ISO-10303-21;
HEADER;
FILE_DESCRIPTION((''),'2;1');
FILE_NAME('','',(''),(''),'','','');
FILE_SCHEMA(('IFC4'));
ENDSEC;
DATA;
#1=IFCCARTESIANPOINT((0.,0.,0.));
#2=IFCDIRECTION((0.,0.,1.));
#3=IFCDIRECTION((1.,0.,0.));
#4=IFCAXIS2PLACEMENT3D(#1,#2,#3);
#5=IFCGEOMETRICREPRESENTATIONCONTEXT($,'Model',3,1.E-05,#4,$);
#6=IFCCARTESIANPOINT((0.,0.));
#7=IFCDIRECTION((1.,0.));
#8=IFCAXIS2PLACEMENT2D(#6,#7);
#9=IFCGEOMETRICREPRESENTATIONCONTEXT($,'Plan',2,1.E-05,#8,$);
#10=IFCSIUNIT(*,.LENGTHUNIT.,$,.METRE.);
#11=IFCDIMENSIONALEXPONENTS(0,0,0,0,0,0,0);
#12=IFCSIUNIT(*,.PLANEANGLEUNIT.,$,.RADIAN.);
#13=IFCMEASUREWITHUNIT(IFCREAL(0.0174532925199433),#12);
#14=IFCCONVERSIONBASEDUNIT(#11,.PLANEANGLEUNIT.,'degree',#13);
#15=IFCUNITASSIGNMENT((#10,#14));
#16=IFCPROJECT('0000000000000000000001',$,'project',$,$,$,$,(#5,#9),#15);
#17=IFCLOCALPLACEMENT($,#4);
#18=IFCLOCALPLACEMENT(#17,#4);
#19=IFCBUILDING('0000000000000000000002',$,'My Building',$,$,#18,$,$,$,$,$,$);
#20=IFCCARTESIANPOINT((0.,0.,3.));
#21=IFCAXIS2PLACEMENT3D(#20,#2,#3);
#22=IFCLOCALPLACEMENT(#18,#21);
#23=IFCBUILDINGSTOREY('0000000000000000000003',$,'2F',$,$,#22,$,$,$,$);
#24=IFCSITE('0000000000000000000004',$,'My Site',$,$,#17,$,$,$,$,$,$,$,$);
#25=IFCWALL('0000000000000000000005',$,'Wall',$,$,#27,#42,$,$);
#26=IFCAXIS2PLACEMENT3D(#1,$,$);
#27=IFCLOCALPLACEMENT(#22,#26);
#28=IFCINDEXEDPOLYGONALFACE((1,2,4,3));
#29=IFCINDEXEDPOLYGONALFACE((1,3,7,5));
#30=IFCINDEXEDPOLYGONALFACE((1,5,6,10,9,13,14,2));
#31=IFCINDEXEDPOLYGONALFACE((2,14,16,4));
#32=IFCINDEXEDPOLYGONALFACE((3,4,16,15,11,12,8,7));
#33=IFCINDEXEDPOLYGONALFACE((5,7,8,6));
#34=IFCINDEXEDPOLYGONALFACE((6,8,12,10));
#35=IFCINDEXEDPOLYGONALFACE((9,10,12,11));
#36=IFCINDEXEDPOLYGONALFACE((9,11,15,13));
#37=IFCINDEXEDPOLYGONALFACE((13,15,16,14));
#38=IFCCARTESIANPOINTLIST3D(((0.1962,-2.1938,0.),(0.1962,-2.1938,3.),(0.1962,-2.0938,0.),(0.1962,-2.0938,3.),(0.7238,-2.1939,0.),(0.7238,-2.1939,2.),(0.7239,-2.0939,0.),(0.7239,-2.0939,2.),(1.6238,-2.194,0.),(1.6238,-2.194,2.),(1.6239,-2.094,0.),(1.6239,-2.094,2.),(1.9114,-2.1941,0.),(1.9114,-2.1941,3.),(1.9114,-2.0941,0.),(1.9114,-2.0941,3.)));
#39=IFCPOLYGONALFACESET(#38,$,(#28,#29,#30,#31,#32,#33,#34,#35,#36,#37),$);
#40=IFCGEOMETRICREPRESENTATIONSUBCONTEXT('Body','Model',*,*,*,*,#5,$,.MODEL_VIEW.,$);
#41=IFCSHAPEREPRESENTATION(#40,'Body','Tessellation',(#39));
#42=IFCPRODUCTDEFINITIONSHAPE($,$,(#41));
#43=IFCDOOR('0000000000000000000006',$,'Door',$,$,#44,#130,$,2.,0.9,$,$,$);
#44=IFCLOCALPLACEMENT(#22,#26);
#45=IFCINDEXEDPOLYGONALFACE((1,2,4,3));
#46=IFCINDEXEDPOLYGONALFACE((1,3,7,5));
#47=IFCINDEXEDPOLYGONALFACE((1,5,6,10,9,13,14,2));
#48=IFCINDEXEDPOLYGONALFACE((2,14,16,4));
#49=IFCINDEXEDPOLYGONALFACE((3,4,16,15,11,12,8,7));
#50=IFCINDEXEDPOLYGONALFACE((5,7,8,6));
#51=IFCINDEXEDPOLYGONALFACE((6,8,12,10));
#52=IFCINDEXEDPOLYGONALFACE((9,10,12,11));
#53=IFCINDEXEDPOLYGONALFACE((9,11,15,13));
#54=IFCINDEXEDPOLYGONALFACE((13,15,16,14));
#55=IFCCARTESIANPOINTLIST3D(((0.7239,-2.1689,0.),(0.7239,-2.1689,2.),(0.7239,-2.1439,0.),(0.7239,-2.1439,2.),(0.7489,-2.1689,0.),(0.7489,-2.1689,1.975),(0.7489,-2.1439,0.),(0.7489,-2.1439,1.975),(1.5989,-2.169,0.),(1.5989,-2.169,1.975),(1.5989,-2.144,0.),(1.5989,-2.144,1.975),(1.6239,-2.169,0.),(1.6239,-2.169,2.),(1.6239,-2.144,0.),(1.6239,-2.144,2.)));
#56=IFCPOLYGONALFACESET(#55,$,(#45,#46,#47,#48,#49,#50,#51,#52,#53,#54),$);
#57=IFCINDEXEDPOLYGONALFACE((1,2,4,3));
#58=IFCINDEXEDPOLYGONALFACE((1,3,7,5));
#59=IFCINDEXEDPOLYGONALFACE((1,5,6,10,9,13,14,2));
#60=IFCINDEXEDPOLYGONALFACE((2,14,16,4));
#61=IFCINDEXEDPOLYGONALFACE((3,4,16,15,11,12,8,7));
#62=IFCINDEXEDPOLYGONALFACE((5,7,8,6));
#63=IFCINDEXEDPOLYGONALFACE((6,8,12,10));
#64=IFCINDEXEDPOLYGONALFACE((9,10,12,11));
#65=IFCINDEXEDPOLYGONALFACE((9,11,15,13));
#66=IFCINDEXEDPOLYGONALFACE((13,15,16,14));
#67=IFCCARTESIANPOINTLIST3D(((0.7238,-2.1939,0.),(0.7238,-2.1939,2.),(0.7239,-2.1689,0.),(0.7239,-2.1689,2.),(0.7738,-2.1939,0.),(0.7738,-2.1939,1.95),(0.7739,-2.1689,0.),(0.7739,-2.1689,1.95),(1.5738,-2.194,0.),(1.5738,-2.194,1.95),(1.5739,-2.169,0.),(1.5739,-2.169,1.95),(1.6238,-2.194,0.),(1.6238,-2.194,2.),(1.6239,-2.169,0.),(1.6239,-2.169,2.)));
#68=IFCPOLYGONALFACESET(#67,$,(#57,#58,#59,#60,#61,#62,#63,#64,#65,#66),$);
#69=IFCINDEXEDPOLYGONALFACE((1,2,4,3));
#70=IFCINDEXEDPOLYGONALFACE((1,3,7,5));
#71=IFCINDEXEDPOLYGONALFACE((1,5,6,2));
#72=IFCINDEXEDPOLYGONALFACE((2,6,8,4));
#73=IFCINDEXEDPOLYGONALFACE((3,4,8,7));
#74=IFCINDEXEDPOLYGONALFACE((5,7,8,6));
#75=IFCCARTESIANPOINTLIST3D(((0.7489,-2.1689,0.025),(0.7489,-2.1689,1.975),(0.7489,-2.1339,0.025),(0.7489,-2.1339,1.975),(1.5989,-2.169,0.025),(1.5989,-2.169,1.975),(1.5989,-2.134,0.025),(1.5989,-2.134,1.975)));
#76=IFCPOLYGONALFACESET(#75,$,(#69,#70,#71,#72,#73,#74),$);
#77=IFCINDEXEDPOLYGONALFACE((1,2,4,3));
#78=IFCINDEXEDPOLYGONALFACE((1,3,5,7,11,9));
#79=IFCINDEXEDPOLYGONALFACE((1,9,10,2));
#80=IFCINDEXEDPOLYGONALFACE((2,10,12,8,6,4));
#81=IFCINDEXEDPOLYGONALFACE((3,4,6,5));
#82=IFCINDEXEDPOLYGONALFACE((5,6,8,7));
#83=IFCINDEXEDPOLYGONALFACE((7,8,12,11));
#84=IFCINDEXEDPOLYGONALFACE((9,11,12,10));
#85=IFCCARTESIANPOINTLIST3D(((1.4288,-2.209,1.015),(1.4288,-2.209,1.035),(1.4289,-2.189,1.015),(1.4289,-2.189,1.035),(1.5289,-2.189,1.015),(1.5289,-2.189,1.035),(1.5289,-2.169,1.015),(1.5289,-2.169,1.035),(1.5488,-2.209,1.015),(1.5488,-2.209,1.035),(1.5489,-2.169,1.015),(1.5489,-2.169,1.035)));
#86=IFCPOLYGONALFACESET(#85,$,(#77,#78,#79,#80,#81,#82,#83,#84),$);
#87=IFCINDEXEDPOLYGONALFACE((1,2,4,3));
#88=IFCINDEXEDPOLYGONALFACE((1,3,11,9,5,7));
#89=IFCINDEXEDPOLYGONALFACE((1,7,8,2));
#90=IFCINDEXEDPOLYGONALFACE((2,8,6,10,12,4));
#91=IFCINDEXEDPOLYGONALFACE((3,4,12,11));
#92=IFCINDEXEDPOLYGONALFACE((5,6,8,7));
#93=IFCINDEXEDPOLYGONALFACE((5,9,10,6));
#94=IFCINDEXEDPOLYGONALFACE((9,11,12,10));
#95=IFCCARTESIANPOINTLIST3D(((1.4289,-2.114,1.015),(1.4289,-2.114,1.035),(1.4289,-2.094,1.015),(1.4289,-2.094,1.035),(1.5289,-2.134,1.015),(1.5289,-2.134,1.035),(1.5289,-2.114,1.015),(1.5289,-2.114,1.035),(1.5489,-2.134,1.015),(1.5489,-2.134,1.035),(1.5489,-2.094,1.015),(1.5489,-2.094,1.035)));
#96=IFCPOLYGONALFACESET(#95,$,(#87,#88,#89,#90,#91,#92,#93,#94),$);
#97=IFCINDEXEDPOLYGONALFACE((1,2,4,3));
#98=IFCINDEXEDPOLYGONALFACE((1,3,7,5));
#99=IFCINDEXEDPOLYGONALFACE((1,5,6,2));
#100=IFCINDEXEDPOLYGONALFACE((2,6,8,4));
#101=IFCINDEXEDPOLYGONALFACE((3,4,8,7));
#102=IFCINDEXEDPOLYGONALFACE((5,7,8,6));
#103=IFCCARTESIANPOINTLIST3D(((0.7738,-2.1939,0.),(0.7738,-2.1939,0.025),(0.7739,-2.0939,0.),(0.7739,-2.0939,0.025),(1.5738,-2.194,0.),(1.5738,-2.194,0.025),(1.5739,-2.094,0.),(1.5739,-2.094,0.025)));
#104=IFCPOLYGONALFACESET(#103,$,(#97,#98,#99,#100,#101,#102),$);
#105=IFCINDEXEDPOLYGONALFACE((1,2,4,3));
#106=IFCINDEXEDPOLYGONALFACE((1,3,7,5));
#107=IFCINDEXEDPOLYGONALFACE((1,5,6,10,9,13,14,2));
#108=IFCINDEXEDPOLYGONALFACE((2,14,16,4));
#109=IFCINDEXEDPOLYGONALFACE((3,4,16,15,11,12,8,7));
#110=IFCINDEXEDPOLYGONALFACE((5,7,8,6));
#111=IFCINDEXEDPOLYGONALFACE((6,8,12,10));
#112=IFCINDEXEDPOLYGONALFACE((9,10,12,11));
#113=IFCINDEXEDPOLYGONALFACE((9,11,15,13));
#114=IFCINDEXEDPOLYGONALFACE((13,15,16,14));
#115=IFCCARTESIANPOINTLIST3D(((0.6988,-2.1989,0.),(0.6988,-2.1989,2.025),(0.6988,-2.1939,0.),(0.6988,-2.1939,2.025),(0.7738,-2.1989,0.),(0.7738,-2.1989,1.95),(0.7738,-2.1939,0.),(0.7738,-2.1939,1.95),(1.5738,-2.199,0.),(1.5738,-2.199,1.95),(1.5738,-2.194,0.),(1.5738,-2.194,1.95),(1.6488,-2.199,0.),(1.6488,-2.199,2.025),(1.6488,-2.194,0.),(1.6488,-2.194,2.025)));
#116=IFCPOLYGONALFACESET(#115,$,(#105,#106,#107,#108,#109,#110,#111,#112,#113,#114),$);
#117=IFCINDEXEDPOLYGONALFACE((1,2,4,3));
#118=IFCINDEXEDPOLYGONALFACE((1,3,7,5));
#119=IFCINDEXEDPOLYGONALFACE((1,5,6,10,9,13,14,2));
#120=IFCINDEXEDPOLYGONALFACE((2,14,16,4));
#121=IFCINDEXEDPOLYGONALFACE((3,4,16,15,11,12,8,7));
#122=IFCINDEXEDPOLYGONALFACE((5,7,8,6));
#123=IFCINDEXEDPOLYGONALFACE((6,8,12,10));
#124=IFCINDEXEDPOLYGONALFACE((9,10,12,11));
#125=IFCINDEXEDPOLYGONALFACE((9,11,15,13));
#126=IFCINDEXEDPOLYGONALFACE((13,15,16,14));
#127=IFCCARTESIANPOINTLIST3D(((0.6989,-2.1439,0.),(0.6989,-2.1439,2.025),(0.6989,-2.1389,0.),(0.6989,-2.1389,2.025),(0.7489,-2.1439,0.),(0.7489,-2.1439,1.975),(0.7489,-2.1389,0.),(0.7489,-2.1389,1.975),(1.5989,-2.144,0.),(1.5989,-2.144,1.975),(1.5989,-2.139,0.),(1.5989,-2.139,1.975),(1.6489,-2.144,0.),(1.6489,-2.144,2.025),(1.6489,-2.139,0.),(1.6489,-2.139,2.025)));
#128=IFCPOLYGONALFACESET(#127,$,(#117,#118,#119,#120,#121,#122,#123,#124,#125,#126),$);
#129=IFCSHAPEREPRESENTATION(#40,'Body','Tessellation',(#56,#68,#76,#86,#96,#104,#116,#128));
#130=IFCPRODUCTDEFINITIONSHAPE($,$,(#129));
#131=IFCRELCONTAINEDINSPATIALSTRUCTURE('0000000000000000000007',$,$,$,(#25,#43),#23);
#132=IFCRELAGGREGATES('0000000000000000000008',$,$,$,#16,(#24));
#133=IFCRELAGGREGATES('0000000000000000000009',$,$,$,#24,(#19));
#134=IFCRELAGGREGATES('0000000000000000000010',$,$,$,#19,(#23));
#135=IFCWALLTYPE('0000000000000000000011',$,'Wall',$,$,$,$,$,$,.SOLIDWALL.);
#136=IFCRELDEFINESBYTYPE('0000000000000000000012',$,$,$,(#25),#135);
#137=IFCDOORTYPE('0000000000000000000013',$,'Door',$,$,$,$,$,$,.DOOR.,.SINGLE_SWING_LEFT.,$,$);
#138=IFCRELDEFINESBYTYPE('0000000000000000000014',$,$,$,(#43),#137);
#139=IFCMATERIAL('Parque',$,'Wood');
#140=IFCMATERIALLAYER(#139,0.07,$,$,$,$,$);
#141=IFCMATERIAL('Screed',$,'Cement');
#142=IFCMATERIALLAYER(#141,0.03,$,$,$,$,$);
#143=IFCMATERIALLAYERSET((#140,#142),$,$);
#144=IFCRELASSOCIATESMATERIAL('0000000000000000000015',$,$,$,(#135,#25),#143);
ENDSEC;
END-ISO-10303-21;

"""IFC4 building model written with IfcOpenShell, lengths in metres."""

from ifc_helpers import new_model, entity, si_unit, converted_unit, frame, origin_with_axes, origin_2d_with_axis, place, context, subcontext, project, spatial, line, indexed_curve, outline, extrude, shape, source, transform, mapped, material, layer, layer_set, layer_usage, type_object, type_shapes, element, fill, save


model = new_model("IFC4")

# Units and contexts
model_context = context("Model", 3, precision=1e-05, world=origin_with_axes())
plan_context = context("Plan", 2, precision=1e-05, world=origin_2d_with_axis())
body_context_1 = subcontext(model_context, "Body", "Model", "MODEL_VIEW")
body_context_2 = subcontext(plan_context, "Body", "Plan", "PLAN_VIEW")
ifc_project = project(units=[si_unit("LENGTHUNIT", "METRE"), converted_unit("PLANEANGLEUNIT", "degree", entity("IfcReal", 0.0174532925199433), si_unit("PLANEANGLEUNIT", "RADIAN"), dimensions=[0, 0, 0, 0, 0, 0, 0])], contexts=[model_context, plan_context])

# Site, building, storey
site_placement = place(None, origin_with_axes())
site = spatial("IfcSite", under=ifc_project, at=site_placement, Name="My Site")
building_placement = place(site_placement, origin_with_axes())
building = spatial("IfcBuilding", under=site, at=building_placement, Name="My Building")
storey_placement = place(building_placement, frame((0.0, 0.0, 3.0), z_axis=(0.0, 0.0, 1.0), x_axis=(1.0, 0.0, 0.0)))
storey = spatial("IfcBuildingStorey", under=building, at=storey_placement, Name="2F")

# Shared definitions
ifc_material_1 = material(Name="Parque", Category="Wood")
ifc_layer_1 = layer(ifc_material_1, 0.07)
ifc_material_2 = material(Name="Screed", Category="Cement")
ifc_layer_2 = layer(ifc_material_2, 0.03)
ifc_layer_set_1 = layer_set([ifc_layer_1, ifc_layer_2])
wall_type = type_object("IfcWallType", Name="Wall", PredefinedType="SOLIDWALL", material=ifc_layer_set_1)

# Shared definitions
shared_shape_1 = source(origin_with_axes(), body_context_1, "Body", "SweptSolid", [
    extrude(outline(indexed_curve([(0.0, 0.0), (0.9, 0.0), (0.9, 2.0), (0.0, 2.0)], segments=[line(1, 2, 3, 4, 1)])), frame((0.0, -0.6, 0.0), z_axis=(0.0, -1.0, 0.0), x_axis=(1.0, 0.0, 0.0)), (0.0, 0.0, -1.0), 1.2),
])
door_type = type_object("IfcDoorType", Name="Door", OperationType="SINGLE_SWING_LEFT", PredefinedType="DOOR")
shared_shape_2 = source(origin_with_axes(), body_context_1, "Body", "SweptSolid", [
    extrude(outline(indexed_curve([(0.0, 0.0), (0.0, 2.0), (0.9, 2.0), (0.9, 0.0), (0.875, 0.0), (0.875, 1.975), (0.025, 1.975), (0.025, 0.0)], segments=[line(1, 2, 3, 4, 5, 6, 7, 8, 1)])), frame((0.0, 0.025, 0.0), z_axis=(0.0, -1.0, 0.0), x_axis=(1.0, 0.0, 0.0)), (0.0, 0.0, -1.0), 0.025),
    extrude(outline(indexed_curve([(0.0, 0.0), (0.0, 2.0), (0.9, 2.0), (0.9, 0.0), (0.85, 0.0), (0.85, 1.95), (0.05, 1.95), (0.05, 0.0)], segments=[line(1, 2, 3, 4, 5, 6, 7, 8, 1)])), frame((0.0, 0.0, 0.0), z_axis=(0.0, -1.0, 0.0), x_axis=(1.0, 0.0, 0.0)), (0.0, 0.0, -1.0), 0.025),
    extrude(outline(indexed_curve([(0.0, 0.0), (0.85, 0.0), (0.85, 0.035), (0.0, 0.035)], segments=[line(1, 2, 3, 4, 1)])), frame((0.025, 0.025, 0.025), z_axis=(0.0, 0.0, 1.0), x_axis=(1.0, 0.0, 0.0)), (0.0, 0.0, 1.0), 1.95),
    extrude(outline(indexed_curve([(0.0, 0.0), (0.0, -0.04), (-0.12, -0.04), (-0.12, -0.02), (-0.02, -0.02), (-0.02, 0.0)], segments=[line(1, 2, 3, 4, 5, 6, 1)])), frame((0.825, 0.025, 1.015), z_axis=(0.0, 0.0, 1.0), x_axis=(1.0, 0.0, 0.0)), (0.0, 0.0, 1.0), 0.02),
    extrude(outline(indexed_curve([(0.0, 0.0), (0.0, 0.04), (-0.12, 0.04), (-0.12, 0.02), (-0.02, 0.02), (-0.02, 0.0)], segments=[line(1, 2, 3, 4, 5, 6, 1)])), frame((0.825, 0.06, 1.015), z_axis=(0.0, 0.0, 1.0), x_axis=(1.0, 0.0, 0.0)), (0.0, 0.0, 1.0), 0.02),
    extrude(outline(indexed_curve([(0.0, 0.0), (0.8, 0.0), (0.8, 0.1), (0.0, 0.1)], segments=[line(1, 2, 3, 4, 1)])), frame((0.05, 0.0, 0.0), z_axis=(0.0, 0.0, 1.0), x_axis=(1.0, 0.0, 0.0)), (0.0, 0.0, 1.0), 0.025),
    extrude(outline(indexed_curve([(0.0, 0.0), (0.0, 2.025), (0.95, 2.025), (0.95, 0.0), (0.875, 0.0), (0.875, 1.95), (0.075, 1.95), (0.075, 0.0)], segments=[line(1, 2, 3, 4, 5, 6, 7, 8, 1)])), frame((-0.025, -0.005, 0.0), z_axis=(0.0, -1.0, 0.0), x_axis=(1.0, 0.0, 0.0)), (0.0, 0.0, -1.0), 0.005),
    extrude(outline(indexed_curve([(0.0, 0.0), (0.0, 2.025), (0.95, 2.025), (0.95, 0.0), (0.9, 0.0), (0.9, 1.975), (0.05, 1.975), (0.05, 0.0)], segments=[line(1, 2, 3, 4, 5, 6, 7, 8, 1)])), frame((-0.025, 0.05, 0.0), z_axis=(0.0, -1.0, 0.0), x_axis=(1.0, 0.0, 0.0)), (0.0, 0.0, -1.0), 0.005),
])
shared_shape_3 = source(origin_with_axes(), body_context_2, "Body", "Curve2D", [
    entity("IfcIndexedPolyCurve", entity("IfcCartesianPointList2D", [[0.0, 0.0], [0.0, 0.05], [0.025, 0.05], [0.025, 0.025], [0.05, 0.025], [0.05, 0.0]]), [entity("IfcLineIndex", [1, 2, 3, 4, 5, 6, 1])]),
    entity("IfcIndexedPolyCurve", entity("IfcCartesianPointList2D", [[0.9, 0.0], [0.9, 0.05], [0.875, 0.05], [0.875, 0.025], [0.85, 0.025], [0.85, 0.0]]), [entity("IfcLineIndex", [1, 2, 3, 4, 5, 6, 1])]),
    entity("IfcTrimmedCurve", entity("IfcEllipse", entity("IfcAxis2Placement2D", entity("IfcCartesianPoint", [0.06, 0.05]), entity("IfcDirection", [1.0, 0.0])), 0.815, 0.85), [entity("IfcCartesianPoint", [0.875, 0.05])], [entity("IfcCartesianPoint", [0.06, 0.9])], True, "CARTESIAN"),
    entity("IfcIndexedPolyCurve", entity("IfcCartesianPointList2D", [[0.025, 0.05], [0.06, 0.05], [0.06, 0.9], [0.025, 0.9]]), [entity("IfcLineIndex", [1, 2, 3, 4, 1])]),
])
type_shapes(door_type, [shared_shape_2, shared_shape_3])

# Wall, opening, door
ifc_layer_usage_1 = layer_usage(ifc_layer_set_1, "AXIS2", "POSITIVE", 0.0)
wall_1_placement = place(storey_placement, frame((0.1962, -2.1938, 0.0), z_axis=(0.0, 0.0, 1.0), x_axis=(1.0, -0.00013, 0.0)))
wall_1 = element("IfcWall", 1, at=wall_1_placement, inside=storey, type_object=wall_type, material=ifc_layer_usage_1, Name="Wall", context=body_context_1, shape_type="SweptSolid", body=[
    extrude(outline(indexed_curve([(0.0, 0.0), (0.0, 0.1), (1.7152, 0.1), (1.7152, 0.0)], segments=[line(1, 2, 3, 4, 1)])), origin_with_axes(), (0.0, 0.0, 1.0), 3.0),
])
opening_1_placement = place(wall_1_placement, frame((0.5276, 0.0, 0.0), z_axis=(0.0, 0.0, 1.0), x_axis=(1.0, 0.0, 0.0)))
opening_1 = element("IfcOpeningElement", 2, at=opening_1_placement, cuts=wall_1, PredefinedType="OPENING", context=body_context_1, shape_type="MappedRepresentation", body=[
    mapped(shared_shape_1, transform((0.0, 0.0, 0.0), x_axis=(1.0, 0.0, 0.0), y_axis=(0.0, 1.0, 0.0), z_axis=(0.0, 0.0, 1.0), scale=1.0)),
])
door_1_placement = place(opening_1_placement, origin_with_axes())
door_1 = element("IfcDoor", 3, at=door_1_placement, inside=storey, type_object=door_type, Name="Door", OverallHeight=2.0, OverallWidth=0.9, shapes=[
    shape(body_context_1, "Body", "MappedRepresentation", [mapped(shared_shape_2, transform((0.0, 0.0, 0.0), x_axis=(1.0, 0.0, 0.0), y_axis=(0.0, 1.0, 0.0), z_axis=(0.0, 0.0, 1.0), scale=1.0))]),
    shape(body_context_2, "Body", "MappedRepresentation", [mapped(shared_shape_3, transform((0.0, 0.0, 0.0), x_axis=(1.0, 0.0, 0.0), y_axis=(0.0, 1.0, 0.0), z_axis=(0.0, 0.0, 1.0), scale=1.0))]),
])
fill(opening_1, door_1)

save(model, "model.ifc")
